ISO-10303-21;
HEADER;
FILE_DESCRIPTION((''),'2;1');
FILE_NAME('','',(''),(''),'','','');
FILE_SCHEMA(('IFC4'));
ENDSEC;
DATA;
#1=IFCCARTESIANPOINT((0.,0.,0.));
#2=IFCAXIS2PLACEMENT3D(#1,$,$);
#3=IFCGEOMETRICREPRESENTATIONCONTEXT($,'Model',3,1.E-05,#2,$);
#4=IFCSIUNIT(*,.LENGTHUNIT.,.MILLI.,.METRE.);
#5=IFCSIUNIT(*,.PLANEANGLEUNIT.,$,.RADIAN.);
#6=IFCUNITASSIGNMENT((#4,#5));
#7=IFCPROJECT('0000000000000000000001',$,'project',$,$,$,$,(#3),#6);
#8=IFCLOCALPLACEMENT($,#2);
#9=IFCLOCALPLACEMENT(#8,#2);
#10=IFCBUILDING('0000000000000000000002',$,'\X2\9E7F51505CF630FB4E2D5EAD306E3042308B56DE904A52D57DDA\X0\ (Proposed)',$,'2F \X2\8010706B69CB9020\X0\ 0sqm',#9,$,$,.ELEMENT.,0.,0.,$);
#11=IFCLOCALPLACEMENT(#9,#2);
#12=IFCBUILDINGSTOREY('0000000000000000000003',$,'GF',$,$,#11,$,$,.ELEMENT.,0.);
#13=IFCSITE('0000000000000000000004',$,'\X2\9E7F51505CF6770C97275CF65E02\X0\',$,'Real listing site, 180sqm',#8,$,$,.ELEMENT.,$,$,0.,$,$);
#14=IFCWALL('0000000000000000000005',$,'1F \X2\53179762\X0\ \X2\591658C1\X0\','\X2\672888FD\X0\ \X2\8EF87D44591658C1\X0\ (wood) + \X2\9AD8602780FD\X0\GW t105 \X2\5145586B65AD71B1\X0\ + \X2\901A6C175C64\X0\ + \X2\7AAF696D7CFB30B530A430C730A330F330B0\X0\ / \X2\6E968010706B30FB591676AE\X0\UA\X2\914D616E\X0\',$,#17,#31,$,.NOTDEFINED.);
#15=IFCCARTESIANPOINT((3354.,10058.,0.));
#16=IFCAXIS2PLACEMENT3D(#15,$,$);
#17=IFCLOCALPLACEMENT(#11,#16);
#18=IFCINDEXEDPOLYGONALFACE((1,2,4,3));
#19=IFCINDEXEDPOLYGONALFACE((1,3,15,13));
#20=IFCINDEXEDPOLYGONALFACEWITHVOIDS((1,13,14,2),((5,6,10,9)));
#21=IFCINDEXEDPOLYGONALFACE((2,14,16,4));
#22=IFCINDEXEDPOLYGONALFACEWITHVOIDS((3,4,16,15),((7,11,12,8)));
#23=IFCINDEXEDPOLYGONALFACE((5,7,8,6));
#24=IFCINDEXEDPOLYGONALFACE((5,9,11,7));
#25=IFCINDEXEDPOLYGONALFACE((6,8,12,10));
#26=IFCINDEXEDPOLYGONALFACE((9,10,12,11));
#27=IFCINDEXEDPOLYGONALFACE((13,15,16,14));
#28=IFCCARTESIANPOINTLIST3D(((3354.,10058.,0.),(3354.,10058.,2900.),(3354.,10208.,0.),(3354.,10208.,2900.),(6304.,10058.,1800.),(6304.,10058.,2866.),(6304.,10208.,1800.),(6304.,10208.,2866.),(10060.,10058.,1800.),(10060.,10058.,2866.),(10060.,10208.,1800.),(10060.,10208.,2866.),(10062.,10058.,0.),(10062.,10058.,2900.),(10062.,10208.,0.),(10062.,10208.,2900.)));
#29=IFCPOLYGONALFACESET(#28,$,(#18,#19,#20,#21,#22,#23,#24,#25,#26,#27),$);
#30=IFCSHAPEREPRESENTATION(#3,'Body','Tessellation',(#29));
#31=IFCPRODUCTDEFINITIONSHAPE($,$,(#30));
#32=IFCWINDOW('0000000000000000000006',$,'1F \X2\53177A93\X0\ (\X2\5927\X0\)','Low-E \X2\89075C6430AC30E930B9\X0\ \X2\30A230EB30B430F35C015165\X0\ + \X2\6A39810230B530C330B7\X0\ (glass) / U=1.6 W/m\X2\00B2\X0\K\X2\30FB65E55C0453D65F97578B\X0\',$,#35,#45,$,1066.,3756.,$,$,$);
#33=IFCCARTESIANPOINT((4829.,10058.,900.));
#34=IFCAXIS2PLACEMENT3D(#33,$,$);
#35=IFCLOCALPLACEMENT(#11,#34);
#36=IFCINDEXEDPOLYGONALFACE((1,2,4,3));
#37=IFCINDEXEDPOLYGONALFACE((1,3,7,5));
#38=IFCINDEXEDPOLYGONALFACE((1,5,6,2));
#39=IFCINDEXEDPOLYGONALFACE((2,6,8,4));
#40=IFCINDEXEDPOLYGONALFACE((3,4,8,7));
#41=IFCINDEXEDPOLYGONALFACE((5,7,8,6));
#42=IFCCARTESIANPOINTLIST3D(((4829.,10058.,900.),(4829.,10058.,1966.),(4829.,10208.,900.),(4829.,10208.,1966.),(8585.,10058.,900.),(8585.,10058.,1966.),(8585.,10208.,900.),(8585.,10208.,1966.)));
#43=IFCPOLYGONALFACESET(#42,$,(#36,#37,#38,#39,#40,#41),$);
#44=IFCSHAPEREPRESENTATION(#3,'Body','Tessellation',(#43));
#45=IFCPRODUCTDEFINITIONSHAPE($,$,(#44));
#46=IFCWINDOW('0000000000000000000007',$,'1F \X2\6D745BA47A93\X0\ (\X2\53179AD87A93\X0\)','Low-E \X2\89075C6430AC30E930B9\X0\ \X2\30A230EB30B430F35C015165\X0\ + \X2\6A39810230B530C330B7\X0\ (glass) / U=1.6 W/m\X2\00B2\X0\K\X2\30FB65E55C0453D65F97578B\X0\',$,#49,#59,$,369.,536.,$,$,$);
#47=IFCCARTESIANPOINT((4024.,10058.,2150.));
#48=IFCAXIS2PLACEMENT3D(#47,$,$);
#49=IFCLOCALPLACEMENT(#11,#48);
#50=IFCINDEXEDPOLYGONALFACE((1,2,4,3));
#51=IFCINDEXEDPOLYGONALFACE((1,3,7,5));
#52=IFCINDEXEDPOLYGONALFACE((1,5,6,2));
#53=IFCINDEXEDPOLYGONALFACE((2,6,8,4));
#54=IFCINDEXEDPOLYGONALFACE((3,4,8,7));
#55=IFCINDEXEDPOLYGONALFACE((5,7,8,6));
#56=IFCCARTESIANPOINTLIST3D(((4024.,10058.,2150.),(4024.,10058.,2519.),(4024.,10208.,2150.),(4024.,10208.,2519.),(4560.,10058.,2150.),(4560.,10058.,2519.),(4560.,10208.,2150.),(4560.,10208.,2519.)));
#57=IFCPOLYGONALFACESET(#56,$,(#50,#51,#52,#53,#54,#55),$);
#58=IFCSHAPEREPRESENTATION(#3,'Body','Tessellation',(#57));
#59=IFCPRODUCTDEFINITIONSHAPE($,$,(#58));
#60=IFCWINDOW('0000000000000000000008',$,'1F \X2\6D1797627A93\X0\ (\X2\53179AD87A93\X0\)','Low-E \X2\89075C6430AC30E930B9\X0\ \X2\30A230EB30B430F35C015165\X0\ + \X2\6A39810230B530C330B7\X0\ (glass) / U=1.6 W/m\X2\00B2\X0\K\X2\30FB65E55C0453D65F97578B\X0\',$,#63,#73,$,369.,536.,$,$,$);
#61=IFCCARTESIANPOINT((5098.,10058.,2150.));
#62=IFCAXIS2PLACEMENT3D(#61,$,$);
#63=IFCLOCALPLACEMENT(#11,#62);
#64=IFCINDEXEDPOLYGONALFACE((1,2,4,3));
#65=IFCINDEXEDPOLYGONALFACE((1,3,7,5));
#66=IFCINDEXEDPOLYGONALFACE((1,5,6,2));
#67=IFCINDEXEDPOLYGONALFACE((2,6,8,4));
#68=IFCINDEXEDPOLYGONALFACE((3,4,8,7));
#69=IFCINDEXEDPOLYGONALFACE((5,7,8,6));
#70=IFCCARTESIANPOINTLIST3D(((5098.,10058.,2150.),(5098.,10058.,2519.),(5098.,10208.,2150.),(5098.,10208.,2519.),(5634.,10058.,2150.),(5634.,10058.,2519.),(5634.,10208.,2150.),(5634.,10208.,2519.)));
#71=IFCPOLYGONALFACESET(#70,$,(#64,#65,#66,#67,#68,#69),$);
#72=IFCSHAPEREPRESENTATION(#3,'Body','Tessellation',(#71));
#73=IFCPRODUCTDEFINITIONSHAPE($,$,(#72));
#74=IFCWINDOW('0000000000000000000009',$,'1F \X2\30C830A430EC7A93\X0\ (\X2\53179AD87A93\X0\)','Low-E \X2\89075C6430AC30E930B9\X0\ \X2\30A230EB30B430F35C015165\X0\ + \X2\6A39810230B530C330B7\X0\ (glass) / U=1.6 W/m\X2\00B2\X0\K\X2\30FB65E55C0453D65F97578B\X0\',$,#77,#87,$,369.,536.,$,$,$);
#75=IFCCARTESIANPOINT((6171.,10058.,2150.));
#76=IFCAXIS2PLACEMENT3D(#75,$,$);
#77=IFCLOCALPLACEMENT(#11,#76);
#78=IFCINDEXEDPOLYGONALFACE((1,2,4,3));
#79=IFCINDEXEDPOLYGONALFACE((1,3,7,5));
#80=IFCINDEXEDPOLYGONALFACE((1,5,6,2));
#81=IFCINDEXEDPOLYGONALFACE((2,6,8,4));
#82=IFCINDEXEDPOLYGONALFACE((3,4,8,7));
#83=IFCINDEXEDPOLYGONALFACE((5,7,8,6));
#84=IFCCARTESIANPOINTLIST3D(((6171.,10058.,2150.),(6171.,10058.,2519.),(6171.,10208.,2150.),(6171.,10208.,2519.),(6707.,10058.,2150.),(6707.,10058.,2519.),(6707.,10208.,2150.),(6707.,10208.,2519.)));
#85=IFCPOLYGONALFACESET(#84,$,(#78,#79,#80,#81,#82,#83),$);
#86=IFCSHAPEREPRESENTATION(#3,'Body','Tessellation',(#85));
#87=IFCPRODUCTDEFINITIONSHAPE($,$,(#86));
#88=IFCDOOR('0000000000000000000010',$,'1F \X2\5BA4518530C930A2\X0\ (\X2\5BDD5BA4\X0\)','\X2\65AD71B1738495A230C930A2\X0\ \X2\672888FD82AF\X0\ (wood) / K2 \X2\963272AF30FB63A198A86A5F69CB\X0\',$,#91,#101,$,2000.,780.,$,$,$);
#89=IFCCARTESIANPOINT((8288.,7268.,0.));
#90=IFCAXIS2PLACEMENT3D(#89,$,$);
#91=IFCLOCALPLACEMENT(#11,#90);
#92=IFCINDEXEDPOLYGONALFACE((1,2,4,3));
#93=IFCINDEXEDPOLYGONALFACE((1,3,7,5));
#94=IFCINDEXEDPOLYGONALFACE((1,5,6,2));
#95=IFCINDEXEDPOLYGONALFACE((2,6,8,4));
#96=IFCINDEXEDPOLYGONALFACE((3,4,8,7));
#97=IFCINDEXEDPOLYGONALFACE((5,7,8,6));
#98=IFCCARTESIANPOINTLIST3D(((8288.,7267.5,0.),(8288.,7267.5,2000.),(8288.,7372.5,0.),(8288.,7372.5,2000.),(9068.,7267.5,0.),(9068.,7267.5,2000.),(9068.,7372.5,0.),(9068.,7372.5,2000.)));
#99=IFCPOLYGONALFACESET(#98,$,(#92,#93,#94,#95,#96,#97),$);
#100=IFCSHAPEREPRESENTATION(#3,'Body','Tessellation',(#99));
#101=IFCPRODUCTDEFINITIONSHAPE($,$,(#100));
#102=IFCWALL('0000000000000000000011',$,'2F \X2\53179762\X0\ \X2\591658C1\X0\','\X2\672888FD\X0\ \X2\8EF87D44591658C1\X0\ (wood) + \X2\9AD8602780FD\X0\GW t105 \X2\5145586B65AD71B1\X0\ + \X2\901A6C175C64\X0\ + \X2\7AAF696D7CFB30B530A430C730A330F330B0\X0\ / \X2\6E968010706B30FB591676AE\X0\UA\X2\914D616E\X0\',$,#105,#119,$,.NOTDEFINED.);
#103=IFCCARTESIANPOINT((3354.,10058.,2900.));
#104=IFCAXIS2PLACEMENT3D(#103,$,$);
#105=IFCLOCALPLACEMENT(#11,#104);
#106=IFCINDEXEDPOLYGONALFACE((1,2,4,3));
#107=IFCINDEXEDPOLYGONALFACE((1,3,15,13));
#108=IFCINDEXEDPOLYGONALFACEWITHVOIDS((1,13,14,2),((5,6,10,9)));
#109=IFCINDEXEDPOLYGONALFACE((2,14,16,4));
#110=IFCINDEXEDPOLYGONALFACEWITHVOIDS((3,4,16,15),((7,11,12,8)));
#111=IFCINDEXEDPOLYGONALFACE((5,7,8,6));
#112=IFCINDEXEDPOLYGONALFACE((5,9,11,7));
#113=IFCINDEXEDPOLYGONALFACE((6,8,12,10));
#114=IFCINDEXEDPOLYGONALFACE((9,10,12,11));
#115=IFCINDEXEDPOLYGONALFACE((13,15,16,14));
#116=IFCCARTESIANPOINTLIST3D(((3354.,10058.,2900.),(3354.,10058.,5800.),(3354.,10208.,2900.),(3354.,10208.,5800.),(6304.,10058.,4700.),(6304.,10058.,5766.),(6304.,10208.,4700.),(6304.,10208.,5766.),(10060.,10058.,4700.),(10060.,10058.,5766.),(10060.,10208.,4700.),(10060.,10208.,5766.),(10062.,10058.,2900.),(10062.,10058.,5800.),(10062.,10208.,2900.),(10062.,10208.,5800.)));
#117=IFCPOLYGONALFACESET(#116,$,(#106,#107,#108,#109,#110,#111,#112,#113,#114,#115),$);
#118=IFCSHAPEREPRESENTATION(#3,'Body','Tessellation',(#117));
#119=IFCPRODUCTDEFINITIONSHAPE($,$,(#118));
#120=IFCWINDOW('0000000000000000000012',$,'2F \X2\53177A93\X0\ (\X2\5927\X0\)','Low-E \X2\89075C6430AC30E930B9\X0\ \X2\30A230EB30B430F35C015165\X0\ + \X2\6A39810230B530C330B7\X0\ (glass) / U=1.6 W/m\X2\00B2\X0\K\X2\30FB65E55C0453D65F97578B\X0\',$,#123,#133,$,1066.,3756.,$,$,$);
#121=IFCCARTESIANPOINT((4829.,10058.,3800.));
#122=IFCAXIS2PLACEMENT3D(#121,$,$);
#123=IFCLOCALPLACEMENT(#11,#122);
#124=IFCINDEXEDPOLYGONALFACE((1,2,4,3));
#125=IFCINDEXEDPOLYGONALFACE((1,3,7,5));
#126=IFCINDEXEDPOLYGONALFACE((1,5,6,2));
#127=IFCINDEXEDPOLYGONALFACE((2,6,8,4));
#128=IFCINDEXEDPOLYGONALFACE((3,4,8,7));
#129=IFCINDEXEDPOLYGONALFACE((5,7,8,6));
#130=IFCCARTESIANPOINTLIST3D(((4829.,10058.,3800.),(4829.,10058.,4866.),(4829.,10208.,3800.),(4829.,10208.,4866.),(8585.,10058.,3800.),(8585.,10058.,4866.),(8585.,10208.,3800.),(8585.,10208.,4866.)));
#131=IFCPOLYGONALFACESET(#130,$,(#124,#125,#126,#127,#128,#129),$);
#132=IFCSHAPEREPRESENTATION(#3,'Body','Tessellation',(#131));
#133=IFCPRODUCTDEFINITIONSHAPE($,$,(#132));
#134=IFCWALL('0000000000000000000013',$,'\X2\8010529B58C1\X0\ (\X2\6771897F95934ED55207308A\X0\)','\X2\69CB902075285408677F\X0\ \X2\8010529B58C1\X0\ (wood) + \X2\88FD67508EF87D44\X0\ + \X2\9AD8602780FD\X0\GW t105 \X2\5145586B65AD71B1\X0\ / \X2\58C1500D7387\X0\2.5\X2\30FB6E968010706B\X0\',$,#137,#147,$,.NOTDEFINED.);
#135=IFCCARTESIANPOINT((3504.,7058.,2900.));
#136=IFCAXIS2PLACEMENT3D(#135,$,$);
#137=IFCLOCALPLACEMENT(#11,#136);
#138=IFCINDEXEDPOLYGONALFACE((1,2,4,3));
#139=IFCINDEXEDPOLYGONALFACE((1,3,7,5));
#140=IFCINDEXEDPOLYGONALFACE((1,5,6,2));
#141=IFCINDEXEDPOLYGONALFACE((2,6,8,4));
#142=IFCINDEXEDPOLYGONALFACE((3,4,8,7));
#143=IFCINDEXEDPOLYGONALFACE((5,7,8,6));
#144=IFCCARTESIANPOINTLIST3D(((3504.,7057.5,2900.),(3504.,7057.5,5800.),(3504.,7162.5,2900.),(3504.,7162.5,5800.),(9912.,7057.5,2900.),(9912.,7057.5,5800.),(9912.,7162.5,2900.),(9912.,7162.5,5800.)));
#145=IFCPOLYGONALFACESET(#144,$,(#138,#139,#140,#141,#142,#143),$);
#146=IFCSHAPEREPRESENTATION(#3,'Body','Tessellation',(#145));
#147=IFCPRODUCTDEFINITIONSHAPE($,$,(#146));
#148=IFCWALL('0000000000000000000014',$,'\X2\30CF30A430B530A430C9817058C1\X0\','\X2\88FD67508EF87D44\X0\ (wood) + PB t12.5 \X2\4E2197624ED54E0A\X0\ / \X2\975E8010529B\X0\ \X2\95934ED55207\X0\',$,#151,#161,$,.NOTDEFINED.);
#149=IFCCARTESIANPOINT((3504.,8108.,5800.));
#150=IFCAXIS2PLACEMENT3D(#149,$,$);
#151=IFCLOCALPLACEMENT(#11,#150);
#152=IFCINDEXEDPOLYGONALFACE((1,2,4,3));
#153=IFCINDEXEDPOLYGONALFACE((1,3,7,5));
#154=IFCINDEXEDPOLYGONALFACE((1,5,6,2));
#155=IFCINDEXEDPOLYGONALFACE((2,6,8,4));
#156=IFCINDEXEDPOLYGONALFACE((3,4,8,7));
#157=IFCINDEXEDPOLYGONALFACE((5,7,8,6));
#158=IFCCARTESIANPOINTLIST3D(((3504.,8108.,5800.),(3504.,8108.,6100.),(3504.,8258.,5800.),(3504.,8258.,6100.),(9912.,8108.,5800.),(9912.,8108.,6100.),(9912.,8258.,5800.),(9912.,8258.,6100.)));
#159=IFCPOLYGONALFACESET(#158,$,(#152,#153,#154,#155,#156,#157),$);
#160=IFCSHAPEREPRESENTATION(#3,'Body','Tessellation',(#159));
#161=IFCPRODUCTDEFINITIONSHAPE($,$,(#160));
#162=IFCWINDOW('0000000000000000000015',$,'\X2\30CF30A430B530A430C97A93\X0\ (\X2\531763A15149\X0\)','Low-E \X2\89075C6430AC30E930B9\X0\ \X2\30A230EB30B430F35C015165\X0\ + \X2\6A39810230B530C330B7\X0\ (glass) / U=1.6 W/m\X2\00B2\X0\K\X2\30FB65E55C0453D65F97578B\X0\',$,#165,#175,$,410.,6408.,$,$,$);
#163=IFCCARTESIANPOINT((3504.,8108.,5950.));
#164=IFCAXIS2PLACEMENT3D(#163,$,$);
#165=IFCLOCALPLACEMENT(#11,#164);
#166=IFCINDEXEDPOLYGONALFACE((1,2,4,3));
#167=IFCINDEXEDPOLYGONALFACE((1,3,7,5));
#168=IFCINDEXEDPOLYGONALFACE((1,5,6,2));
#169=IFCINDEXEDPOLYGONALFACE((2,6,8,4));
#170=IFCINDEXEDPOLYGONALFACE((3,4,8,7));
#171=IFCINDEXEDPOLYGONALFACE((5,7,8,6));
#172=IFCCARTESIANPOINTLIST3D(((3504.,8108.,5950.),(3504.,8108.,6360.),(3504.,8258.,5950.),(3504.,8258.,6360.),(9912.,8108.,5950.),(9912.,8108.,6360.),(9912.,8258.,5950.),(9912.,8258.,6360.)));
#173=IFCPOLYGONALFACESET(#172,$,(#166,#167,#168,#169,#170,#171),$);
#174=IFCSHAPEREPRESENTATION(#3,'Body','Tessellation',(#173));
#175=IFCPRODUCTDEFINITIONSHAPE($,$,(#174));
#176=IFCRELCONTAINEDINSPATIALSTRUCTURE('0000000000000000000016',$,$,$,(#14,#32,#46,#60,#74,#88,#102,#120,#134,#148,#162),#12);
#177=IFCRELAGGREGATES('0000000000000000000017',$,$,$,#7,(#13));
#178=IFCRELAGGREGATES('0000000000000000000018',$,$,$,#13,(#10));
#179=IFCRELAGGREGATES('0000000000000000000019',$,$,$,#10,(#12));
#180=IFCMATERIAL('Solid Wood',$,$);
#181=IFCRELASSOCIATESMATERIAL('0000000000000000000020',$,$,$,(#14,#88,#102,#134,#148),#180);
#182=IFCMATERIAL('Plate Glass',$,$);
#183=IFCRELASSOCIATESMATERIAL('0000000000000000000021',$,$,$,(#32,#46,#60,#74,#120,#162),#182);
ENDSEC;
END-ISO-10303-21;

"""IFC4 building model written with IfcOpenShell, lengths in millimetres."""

from ifc_helpers import new_model, si_unit, frame, frame_2d, origin, place, context, project, spatial, rectangle, extrude, material, element, fill, save


model = new_model("IFC4")

# Units and contexts
model_context = context("Model", 3, precision=1e-05, world=origin())
ifc_project = project(units=[si_unit("LENGTHUNIT", "METRE", prefix="MILLI"), si_unit("PLANEANGLEUNIT", "RADIAN")], contexts=[model_context])

# Site, building, storey
site_placement = place(None, origin())
site = spatial("IfcSite", under=ifc_project, at=site_placement, Name="鹿児島県霧島市", ObjectType="Real listing site, 180sqm", CompositionType="ELEMENT", RefElevation=0.0)
building_placement = place(site_placement, origin())
building = spatial("IfcBuilding", under=site, at=building_placement, Name="鹿児島・中庭のある回遊動線 (Proposed)", ObjectType="2F 耐火構造 0sqm", CompositionType="ELEMENT", ElevationOfRefHeight=0.0, ElevationOfTerrain=0.0)
storey_placement = place(building_placement, origin())
storey = spatial("IfcBuildingStorey", under=building, at=storey_placement, Name="GF", CompositionType="ELEMENT", Elevation=0.0)

# Wall, openings, windows
ifc_material_1 = material(Name="Solid Wood")
wall_1_placement = place(storey_placement, frame((3354.0, 10058.0, 0.0)))
wall_1 = element("IfcWall", 1, at=wall_1_placement, inside=storey, material=ifc_material_1, Name="1F 北面 外壁", Description="木製 軸組外壁 (wood) + 高性能GW t105 充填断熱 + 通気層 + 窯業系サイディング / 準耐火・外皮UA配慮", PredefinedType="NOTDEFINED", context=model_context, shape_type="SweptSolid", body=[
    extrude(rectangle(XDim=6708.0, YDim=150.0, at=frame_2d((3354.0, 75.0))), frame((3354.0, 10058.0, 0.0)), (0.0, 0.0, 1.0), 2900.0),
])
opening_1_placement = place(storey_placement, frame((4829.0, 10058.0, 900.0)))
opening_1 = element("IfcOpeningElement", 2, at=opening_1_placement, cuts=wall_1, PredefinedType="NOTDEFINED", context=model_context, shape_type="SweptSolid", body=[
    extrude(rectangle(XDim=3756.0, YDim=150.0, at=frame_2d((1878.0, 75.0))), frame((4829.0, 10058.0, 900.0)), (0.0, 0.0, 1.0), 1066.0),
])
opening_2_placement = place(storey_placement, frame((4024.0, 10058.0, 2150.0)))
opening_2 = element("IfcOpeningElement", 3, at=opening_2_placement, cuts=wall_1, PredefinedType="NOTDEFINED", context=model_context, shape_type="SweptSolid", body=[
    extrude(rectangle(XDim=536.0, YDim=150.0, at=frame_2d((268.0, 75.0))), frame((4024.0, 10058.0, 2150.0)), (0.0, 0.0, 1.0), 369.0),
])
opening_3_placement = place(storey_placement, frame((5098.0, 10058.0, 2150.0)))
opening_3 = element("IfcOpeningElement", 4, at=opening_3_placement, cuts=wall_1, PredefinedType="NOTDEFINED", context=model_context, shape_type="SweptSolid", body=[
    extrude(rectangle(XDim=536.0, YDim=150.0, at=frame_2d((268.0, 75.0))), frame((5098.0, 10058.0, 2150.0)), (0.0, 0.0, 1.0), 369.0),
])
opening_4_placement = place(storey_placement, frame((6171.0, 10058.0, 2150.0)))
opening_4 = element("IfcOpeningElement", 5, at=opening_4_placement, cuts=wall_1, PredefinedType="NOTDEFINED", context=model_context, shape_type="SweptSolid", body=[
    extrude(rectangle(XDim=536.0, YDim=150.0, at=frame_2d((268.0, 75.0))), frame((6171.0, 10058.0, 2150.0)), (0.0, 0.0, 1.0), 369.0),
])
ifc_material_2 = material(Name="Plate Glass")
window_1_placement = place(storey_placement, frame((4829.0, 10058.0, 900.0)))
window_1 = element("IfcWindow", 6, at=window_1_placement, inside=storey, material=ifc_material_2, Name="1F 北窓 (大)", Description="Low-E 複層ガラス アルゴン封入 + 樹脂サッシ (glass) / U=1.6 W/m²K・日射取得型", OverallHeight=1066.0, OverallWidth=3756.0, context=model_context, shape_type="SweptSolid", body=[
    extrude(rectangle(XDim=3756.0, YDim=150.0, at=frame_2d((1878.0, 75.0))), frame((4829.0, 10058.0, 900.0)), (0.0, 0.0, 1.0), 1066.0),
])
fill(opening_1, window_1)
window_2_placement = place(storey_placement, frame((4024.0, 10058.0, 2150.0)))
window_2 = element("IfcWindow", 7, at=window_2_placement, inside=storey, material=ifc_material_2, Name="1F 浴室窓 (北高窓)", Description="Low-E 複層ガラス アルゴン封入 + 樹脂サッシ (glass) / U=1.6 W/m²K・日射取得型", OverallHeight=369.0, OverallWidth=536.0, context=model_context, shape_type="SweptSolid", body=[
    extrude(rectangle(XDim=536.0, YDim=150.0, at=frame_2d((268.0, 75.0))), frame((4024.0, 10058.0, 2150.0)), (0.0, 0.0, 1.0), 369.0),
])
fill(opening_2, window_2)
window_3_placement = place(storey_placement, frame((5098.0, 10058.0, 2150.0)))
window_3 = element("IfcWindow", 8, at=window_3_placement, inside=storey, material=ifc_material_2, Name="1F 洗面窓 (北高窓)", Description="Low-E 複層ガラス アルゴン封入 + 樹脂サッシ (glass) / U=1.6 W/m²K・日射取得型", OverallHeight=369.0, OverallWidth=536.0, context=model_context, shape_type="SweptSolid", body=[
    extrude(rectangle(XDim=536.0, YDim=150.0, at=frame_2d((268.0, 75.0))), frame((5098.0, 10058.0, 2150.0)), (0.0, 0.0, 1.0), 369.0),
])
fill(opening_3, window_3)
window_4_placement = place(storey_placement, frame((6171.0, 10058.0, 2150.0)))
window_4 = element("IfcWindow", 9, at=window_4_placement, inside=storey, material=ifc_material_2, Name="1F トイレ窓 (北高窓)", Description="Low-E 複層ガラス アルゴン封入 + 樹脂サッシ (glass) / U=1.6 W/m²K・日射取得型", OverallHeight=369.0, OverallWidth=536.0, context=model_context, shape_type="SweptSolid", body=[
    extrude(rectangle(XDim=536.0, YDim=150.0, at=frame_2d((268.0, 75.0))), frame((6171.0, 10058.0, 2150.0)), (0.0, 0.0, 1.0), 369.0),
])
fill(opening_4, window_4)

# Door
door_1_placement = place(storey_placement, frame((8288.0, 7268.0, 0.0)))
element("IfcDoor", 10, at=door_1_placement, inside=storey, material=ifc_material_1, Name="1F 室内ドア (寝室)", Description="断熱玄関ドア 木製芯 (wood) / K2 防犯・採風機構", OverallHeight=2000.0, OverallWidth=780.0, context=model_context, shape_type="SweptSolid", body=[
    extrude(rectangle(XDim=780.0, YDim=105.0, at=frame_2d((390.0, 52.0))), frame((8288.0, 7268.0, 0.0)), (0.0, 0.0, 1.0), 2000.0),
])

# Wall, opening, window
wall_2_placement = place(storey_placement, frame((3354.0, 10058.0, 2900.0)))
wall_2 = element("IfcWall", 11, at=wall_2_placement, inside=storey, material=ifc_material_1, Name="2F 北面 外壁", Description="木製 軸組外壁 (wood) + 高性能GW t105 充填断熱 + 通気層 + 窯業系サイディング / 準耐火・外皮UA配慮", PredefinedType="NOTDEFINED", context=model_context, shape_type="SweptSolid", body=[
    extrude(rectangle(XDim=6708.0, YDim=150.0, at=frame_2d((3354.0, 75.0))), frame((3354.0, 10058.0, 2900.0)), (0.0, 0.0, 1.0), 2900.0),
])
opening_5_placement = place(storey_placement, frame((4829.0, 10058.0, 3800.0)))
opening_5 = element("IfcOpeningElement", 12, at=opening_5_placement, cuts=wall_2, PredefinedType="NOTDEFINED", context=model_context, shape_type="SweptSolid", body=[
    extrude(rectangle(XDim=3756.0, YDim=150.0, at=frame_2d((1878.0, 75.0))), frame((4829.0, 10058.0, 3800.0)), (0.0, 0.0, 1.0), 1066.0),
])
window_5_placement = place(storey_placement, frame((4829.0, 10058.0, 3800.0)))
window_5 = element("IfcWindow", 13, at=window_5_placement, inside=storey, material=ifc_material_2, Name="2F 北窓 (大)", Description="Low-E 複層ガラス アルゴン封入 + 樹脂サッシ (glass) / U=1.6 W/m²K・日射取得型", OverallHeight=1066.0, OverallWidth=3756.0, context=model_context, shape_type="SweptSolid", body=[
    extrude(rectangle(XDim=3756.0, YDim=150.0, at=frame_2d((1878.0, 75.0))), frame((4829.0, 10058.0, 3800.0)), (0.0, 0.0, 1.0), 1066.0),
])
fill(opening_5, window_5)

# Wall
wall_3_placement = place(storey_placement, frame((3504.0, 7058.0, 2900.0)))
element("IfcWall", 14, at=wall_3_placement, inside=storey, material=ifc_material_1, Name="耐力壁 (東西間仕切り)", Description="構造用合板 耐力壁 (wood) + 製材軸組 + 高性能GW t105 充填断熱 / 壁倍率2.5・準耐火", PredefinedType="NOTDEFINED", context=model_context, shape_type="SweptSolid", body=[
    extrude(rectangle(XDim=6408.0, YDim=105.0, at=frame_2d((3204.0, 52.0))), frame((3504.0, 7058.0, 2900.0)), (0.0, 0.0, 1.0), 2900.0),
])

# Wall, opening, window
wall_4_placement = place(storey_placement, frame((3504.0, 8108.0, 5800.0)))
wall_4 = element("IfcWall", 15, at=wall_4_placement, inside=storey, material=ifc_material_1, Name="ハイサイド腰壁", Description="製材軸組 (wood) + PB t12.5 両面仕上 / 非耐力 間仕切", PredefinedType="NOTDEFINED", context=model_context, shape_type="SweptSolid", body=[
    extrude(rectangle(XDim=6408.0, YDim=150.0, at=frame_2d((3204.0, 75.0))), frame((3504.0, 8108.0, 5800.0)), (0.0, 0.0, 1.0), 700.0),
])
opening_6_placement = place(storey_placement, frame((3504.0, 8108.0, 5950.0)))
opening_6 = element("IfcOpeningElement", 16, at=opening_6_placement, cuts=wall_4, PredefinedType="NOTDEFINED", context=model_context, shape_type="SweptSolid", body=[
    extrude(rectangle(XDim=6408.0, YDim=150.0, at=frame_2d((3204.0, 75.0))), frame((3504.0, 8108.0, 5950.0)), (0.0, 0.0, 1.0), 410.0),
])
window_6_placement = place(storey_placement, frame((3504.0, 8108.0, 5950.0)))
window_6 = element("IfcWindow", 17, at=window_6_placement, inside=storey, material=ifc_material_2, Name="ハイサイド窓 (北採光)", Description="Low-E 複層ガラス アルゴン封入 + 樹脂サッシ (glass) / U=1.6 W/m²K・日射取得型", OverallHeight=410.0, OverallWidth=6408.0, context=model_context, shape_type="SweptSolid", body=[
    extrude(rectangle(XDim=6408.0, YDim=150.0, at=frame_2d((3204.0, 75.0))), frame((3504.0, 8108.0, 5950.0)), (0.0, 0.0, 1.0), 410.0),
])
fill(opening_6, window_6)

save(model, "model.ifc")
